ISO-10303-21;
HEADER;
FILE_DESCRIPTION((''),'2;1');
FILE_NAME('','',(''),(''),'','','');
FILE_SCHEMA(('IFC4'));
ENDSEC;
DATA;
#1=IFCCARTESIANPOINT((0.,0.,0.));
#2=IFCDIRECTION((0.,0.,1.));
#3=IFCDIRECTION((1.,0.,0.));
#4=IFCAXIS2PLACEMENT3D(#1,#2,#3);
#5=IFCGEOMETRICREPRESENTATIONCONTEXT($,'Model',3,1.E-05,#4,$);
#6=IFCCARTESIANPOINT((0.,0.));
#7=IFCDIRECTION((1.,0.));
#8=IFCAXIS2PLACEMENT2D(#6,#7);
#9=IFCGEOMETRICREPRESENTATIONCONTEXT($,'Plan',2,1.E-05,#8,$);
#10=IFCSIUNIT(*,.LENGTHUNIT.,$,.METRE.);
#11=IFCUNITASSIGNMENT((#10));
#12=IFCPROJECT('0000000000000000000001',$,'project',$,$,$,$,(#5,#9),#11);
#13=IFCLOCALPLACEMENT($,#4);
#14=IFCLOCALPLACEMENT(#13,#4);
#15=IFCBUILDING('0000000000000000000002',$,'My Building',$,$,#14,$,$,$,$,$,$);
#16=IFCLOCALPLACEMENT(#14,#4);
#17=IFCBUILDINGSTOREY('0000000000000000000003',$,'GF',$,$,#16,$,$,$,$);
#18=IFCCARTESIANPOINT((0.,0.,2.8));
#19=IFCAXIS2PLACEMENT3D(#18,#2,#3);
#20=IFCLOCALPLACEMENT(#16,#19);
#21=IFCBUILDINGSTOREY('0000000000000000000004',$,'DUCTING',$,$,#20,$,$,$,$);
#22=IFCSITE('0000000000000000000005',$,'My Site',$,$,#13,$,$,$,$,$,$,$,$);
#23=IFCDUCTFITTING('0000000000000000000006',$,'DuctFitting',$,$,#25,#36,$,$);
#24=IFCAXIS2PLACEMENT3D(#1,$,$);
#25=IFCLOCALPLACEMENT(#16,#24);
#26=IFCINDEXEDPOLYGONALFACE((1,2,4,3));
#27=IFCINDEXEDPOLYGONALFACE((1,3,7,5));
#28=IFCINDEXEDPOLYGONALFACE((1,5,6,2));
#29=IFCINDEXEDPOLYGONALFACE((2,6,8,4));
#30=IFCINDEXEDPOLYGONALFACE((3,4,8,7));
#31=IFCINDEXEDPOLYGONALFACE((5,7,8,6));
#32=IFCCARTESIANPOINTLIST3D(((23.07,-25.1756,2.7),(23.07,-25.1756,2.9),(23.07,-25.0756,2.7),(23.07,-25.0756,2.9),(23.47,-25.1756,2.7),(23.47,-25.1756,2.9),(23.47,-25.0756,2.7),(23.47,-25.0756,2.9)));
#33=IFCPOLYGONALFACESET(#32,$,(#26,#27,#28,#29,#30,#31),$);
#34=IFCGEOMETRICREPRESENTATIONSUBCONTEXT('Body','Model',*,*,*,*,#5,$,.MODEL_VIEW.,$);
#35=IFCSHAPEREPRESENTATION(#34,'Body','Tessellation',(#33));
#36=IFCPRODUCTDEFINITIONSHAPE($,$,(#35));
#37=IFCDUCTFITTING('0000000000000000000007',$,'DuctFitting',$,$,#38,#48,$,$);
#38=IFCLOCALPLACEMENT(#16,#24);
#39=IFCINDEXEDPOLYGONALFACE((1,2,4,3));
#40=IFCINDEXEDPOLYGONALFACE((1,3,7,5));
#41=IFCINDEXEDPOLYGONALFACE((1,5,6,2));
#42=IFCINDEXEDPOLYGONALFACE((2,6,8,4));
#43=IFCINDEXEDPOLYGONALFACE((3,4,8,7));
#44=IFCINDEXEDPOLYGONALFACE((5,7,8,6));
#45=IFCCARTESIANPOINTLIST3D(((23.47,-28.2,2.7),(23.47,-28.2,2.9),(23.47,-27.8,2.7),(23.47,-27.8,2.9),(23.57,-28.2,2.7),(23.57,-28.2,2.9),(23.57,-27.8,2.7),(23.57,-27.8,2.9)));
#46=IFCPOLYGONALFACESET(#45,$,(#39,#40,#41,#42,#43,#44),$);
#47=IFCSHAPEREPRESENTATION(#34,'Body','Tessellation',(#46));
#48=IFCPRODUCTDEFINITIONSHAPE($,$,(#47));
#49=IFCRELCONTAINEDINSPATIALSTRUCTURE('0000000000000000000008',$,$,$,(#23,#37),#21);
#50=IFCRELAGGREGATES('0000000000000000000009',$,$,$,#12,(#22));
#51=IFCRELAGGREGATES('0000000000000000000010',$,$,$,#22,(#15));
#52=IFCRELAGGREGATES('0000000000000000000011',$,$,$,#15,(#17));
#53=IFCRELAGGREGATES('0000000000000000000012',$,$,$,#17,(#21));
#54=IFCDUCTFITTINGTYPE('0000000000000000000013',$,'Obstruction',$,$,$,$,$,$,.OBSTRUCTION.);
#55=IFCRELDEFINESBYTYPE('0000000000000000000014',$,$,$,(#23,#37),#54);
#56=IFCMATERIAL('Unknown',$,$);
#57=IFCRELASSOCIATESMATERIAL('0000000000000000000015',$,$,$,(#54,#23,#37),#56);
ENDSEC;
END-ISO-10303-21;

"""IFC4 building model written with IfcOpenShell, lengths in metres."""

from ifc_helpers import new_model, si_unit, frame, origin_with_axes, origin_2d_with_axis, place, context, subcontext, project, spatial, rectangle, extrude, material, material_profile, profile_set, profile_usage, type_object, element, save


model = new_model("IFC4")

# Units and contexts
model_context = context("Model", 3, precision=1e-05, world=origin_with_axes())
plan_context = context("Plan", 2, precision=1e-05, world=origin_2d_with_axis())
body_context = subcontext(model_context, "Body", "Model", "MODEL_VIEW")
ifc_project = project(units=[si_unit("LENGTHUNIT", "METRE")], contexts=[model_context, plan_context])

# Site, building, storeys
site_placement = place(None, origin_with_axes())
site = spatial("IfcSite", under=ifc_project, at=site_placement, Name="My Site")
building_placement = place(site_placement, origin_with_axes())
building = spatial("IfcBuilding", under=site, at=building_placement, Name="My Building")
storey_1_placement = place(building_placement, origin_with_axes())
storey_1 = spatial("IfcBuildingStorey", under=building, at=storey_1_placement, Name="GF")
storey_2_placement = place(storey_1_placement, frame((0.0, 0.0, 2.8), z_axis=(0.0, 0.0, 1.0), x_axis=(1.0, 0.0, 0.0)))
storey_2 = spatial("IfcBuildingStorey", under=storey_1, at=storey_2_placement, Name="DUCTING")

# Shared definitions
ifc_material = material(Name="Unknown")

# Duct fittings
ifc_material_profile_1 = material_profile(ifc_material, rectangle(XDim=0.4, YDim=0.2))
ifc_profile_set_1 = profile_set([ifc_material_profile_1])
duct_fitting_type_1 = type_object("IfcDuctFittingType", Name="Obstruction", PredefinedType="OBSTRUCTION", material=ifc_profile_set_1)
ifc_profile_usage_1 = profile_usage(ifc_profile_set_1, cardinal=5)
duct_fitting_1_placement = place(storey_2_placement, frame((23.27, -25.1756, 0.0), z_axis=(0.0, 1.0, 0.0), x_axis=(-1.0, 0.0, 0.0)))
element("IfcDuctFitting", 1, at=duct_fitting_1_placement, inside=storey_2, type_object=duct_fitting_type_1, material=ifc_profile_usage_1, Name="DuctFitting", context=body_context, shape_type="SweptSolid", body=[
    extrude(rectangle(XDim=0.4, YDim=0.2), origin_with_axes(), (0.0, 0.0, 1.0), 0.1),
])
ifc_profile_usage_2 = profile_usage(ifc_profile_set_1, cardinal=5)
duct_fitting_2_placement = place(storey_2_placement, frame((23.47, -28.0, 0.0), z_axis=(1.0, 0.0, 0.0), x_axis=(0.0, 1.0, 0.0)))
element("IfcDuctFitting", 2, at=duct_fitting_2_placement, inside=storey_2, type_object=duct_fitting_type_1, material=ifc_profile_usage_2, Name="DuctFitting", context=body_context, shape_type="SweptSolid", body=[
    extrude(rectangle(XDim=0.4, YDim=0.2), origin_with_axes(), (0.0, 0.0, 1.0), 0.1),
])

save(model, "model.ifc")
